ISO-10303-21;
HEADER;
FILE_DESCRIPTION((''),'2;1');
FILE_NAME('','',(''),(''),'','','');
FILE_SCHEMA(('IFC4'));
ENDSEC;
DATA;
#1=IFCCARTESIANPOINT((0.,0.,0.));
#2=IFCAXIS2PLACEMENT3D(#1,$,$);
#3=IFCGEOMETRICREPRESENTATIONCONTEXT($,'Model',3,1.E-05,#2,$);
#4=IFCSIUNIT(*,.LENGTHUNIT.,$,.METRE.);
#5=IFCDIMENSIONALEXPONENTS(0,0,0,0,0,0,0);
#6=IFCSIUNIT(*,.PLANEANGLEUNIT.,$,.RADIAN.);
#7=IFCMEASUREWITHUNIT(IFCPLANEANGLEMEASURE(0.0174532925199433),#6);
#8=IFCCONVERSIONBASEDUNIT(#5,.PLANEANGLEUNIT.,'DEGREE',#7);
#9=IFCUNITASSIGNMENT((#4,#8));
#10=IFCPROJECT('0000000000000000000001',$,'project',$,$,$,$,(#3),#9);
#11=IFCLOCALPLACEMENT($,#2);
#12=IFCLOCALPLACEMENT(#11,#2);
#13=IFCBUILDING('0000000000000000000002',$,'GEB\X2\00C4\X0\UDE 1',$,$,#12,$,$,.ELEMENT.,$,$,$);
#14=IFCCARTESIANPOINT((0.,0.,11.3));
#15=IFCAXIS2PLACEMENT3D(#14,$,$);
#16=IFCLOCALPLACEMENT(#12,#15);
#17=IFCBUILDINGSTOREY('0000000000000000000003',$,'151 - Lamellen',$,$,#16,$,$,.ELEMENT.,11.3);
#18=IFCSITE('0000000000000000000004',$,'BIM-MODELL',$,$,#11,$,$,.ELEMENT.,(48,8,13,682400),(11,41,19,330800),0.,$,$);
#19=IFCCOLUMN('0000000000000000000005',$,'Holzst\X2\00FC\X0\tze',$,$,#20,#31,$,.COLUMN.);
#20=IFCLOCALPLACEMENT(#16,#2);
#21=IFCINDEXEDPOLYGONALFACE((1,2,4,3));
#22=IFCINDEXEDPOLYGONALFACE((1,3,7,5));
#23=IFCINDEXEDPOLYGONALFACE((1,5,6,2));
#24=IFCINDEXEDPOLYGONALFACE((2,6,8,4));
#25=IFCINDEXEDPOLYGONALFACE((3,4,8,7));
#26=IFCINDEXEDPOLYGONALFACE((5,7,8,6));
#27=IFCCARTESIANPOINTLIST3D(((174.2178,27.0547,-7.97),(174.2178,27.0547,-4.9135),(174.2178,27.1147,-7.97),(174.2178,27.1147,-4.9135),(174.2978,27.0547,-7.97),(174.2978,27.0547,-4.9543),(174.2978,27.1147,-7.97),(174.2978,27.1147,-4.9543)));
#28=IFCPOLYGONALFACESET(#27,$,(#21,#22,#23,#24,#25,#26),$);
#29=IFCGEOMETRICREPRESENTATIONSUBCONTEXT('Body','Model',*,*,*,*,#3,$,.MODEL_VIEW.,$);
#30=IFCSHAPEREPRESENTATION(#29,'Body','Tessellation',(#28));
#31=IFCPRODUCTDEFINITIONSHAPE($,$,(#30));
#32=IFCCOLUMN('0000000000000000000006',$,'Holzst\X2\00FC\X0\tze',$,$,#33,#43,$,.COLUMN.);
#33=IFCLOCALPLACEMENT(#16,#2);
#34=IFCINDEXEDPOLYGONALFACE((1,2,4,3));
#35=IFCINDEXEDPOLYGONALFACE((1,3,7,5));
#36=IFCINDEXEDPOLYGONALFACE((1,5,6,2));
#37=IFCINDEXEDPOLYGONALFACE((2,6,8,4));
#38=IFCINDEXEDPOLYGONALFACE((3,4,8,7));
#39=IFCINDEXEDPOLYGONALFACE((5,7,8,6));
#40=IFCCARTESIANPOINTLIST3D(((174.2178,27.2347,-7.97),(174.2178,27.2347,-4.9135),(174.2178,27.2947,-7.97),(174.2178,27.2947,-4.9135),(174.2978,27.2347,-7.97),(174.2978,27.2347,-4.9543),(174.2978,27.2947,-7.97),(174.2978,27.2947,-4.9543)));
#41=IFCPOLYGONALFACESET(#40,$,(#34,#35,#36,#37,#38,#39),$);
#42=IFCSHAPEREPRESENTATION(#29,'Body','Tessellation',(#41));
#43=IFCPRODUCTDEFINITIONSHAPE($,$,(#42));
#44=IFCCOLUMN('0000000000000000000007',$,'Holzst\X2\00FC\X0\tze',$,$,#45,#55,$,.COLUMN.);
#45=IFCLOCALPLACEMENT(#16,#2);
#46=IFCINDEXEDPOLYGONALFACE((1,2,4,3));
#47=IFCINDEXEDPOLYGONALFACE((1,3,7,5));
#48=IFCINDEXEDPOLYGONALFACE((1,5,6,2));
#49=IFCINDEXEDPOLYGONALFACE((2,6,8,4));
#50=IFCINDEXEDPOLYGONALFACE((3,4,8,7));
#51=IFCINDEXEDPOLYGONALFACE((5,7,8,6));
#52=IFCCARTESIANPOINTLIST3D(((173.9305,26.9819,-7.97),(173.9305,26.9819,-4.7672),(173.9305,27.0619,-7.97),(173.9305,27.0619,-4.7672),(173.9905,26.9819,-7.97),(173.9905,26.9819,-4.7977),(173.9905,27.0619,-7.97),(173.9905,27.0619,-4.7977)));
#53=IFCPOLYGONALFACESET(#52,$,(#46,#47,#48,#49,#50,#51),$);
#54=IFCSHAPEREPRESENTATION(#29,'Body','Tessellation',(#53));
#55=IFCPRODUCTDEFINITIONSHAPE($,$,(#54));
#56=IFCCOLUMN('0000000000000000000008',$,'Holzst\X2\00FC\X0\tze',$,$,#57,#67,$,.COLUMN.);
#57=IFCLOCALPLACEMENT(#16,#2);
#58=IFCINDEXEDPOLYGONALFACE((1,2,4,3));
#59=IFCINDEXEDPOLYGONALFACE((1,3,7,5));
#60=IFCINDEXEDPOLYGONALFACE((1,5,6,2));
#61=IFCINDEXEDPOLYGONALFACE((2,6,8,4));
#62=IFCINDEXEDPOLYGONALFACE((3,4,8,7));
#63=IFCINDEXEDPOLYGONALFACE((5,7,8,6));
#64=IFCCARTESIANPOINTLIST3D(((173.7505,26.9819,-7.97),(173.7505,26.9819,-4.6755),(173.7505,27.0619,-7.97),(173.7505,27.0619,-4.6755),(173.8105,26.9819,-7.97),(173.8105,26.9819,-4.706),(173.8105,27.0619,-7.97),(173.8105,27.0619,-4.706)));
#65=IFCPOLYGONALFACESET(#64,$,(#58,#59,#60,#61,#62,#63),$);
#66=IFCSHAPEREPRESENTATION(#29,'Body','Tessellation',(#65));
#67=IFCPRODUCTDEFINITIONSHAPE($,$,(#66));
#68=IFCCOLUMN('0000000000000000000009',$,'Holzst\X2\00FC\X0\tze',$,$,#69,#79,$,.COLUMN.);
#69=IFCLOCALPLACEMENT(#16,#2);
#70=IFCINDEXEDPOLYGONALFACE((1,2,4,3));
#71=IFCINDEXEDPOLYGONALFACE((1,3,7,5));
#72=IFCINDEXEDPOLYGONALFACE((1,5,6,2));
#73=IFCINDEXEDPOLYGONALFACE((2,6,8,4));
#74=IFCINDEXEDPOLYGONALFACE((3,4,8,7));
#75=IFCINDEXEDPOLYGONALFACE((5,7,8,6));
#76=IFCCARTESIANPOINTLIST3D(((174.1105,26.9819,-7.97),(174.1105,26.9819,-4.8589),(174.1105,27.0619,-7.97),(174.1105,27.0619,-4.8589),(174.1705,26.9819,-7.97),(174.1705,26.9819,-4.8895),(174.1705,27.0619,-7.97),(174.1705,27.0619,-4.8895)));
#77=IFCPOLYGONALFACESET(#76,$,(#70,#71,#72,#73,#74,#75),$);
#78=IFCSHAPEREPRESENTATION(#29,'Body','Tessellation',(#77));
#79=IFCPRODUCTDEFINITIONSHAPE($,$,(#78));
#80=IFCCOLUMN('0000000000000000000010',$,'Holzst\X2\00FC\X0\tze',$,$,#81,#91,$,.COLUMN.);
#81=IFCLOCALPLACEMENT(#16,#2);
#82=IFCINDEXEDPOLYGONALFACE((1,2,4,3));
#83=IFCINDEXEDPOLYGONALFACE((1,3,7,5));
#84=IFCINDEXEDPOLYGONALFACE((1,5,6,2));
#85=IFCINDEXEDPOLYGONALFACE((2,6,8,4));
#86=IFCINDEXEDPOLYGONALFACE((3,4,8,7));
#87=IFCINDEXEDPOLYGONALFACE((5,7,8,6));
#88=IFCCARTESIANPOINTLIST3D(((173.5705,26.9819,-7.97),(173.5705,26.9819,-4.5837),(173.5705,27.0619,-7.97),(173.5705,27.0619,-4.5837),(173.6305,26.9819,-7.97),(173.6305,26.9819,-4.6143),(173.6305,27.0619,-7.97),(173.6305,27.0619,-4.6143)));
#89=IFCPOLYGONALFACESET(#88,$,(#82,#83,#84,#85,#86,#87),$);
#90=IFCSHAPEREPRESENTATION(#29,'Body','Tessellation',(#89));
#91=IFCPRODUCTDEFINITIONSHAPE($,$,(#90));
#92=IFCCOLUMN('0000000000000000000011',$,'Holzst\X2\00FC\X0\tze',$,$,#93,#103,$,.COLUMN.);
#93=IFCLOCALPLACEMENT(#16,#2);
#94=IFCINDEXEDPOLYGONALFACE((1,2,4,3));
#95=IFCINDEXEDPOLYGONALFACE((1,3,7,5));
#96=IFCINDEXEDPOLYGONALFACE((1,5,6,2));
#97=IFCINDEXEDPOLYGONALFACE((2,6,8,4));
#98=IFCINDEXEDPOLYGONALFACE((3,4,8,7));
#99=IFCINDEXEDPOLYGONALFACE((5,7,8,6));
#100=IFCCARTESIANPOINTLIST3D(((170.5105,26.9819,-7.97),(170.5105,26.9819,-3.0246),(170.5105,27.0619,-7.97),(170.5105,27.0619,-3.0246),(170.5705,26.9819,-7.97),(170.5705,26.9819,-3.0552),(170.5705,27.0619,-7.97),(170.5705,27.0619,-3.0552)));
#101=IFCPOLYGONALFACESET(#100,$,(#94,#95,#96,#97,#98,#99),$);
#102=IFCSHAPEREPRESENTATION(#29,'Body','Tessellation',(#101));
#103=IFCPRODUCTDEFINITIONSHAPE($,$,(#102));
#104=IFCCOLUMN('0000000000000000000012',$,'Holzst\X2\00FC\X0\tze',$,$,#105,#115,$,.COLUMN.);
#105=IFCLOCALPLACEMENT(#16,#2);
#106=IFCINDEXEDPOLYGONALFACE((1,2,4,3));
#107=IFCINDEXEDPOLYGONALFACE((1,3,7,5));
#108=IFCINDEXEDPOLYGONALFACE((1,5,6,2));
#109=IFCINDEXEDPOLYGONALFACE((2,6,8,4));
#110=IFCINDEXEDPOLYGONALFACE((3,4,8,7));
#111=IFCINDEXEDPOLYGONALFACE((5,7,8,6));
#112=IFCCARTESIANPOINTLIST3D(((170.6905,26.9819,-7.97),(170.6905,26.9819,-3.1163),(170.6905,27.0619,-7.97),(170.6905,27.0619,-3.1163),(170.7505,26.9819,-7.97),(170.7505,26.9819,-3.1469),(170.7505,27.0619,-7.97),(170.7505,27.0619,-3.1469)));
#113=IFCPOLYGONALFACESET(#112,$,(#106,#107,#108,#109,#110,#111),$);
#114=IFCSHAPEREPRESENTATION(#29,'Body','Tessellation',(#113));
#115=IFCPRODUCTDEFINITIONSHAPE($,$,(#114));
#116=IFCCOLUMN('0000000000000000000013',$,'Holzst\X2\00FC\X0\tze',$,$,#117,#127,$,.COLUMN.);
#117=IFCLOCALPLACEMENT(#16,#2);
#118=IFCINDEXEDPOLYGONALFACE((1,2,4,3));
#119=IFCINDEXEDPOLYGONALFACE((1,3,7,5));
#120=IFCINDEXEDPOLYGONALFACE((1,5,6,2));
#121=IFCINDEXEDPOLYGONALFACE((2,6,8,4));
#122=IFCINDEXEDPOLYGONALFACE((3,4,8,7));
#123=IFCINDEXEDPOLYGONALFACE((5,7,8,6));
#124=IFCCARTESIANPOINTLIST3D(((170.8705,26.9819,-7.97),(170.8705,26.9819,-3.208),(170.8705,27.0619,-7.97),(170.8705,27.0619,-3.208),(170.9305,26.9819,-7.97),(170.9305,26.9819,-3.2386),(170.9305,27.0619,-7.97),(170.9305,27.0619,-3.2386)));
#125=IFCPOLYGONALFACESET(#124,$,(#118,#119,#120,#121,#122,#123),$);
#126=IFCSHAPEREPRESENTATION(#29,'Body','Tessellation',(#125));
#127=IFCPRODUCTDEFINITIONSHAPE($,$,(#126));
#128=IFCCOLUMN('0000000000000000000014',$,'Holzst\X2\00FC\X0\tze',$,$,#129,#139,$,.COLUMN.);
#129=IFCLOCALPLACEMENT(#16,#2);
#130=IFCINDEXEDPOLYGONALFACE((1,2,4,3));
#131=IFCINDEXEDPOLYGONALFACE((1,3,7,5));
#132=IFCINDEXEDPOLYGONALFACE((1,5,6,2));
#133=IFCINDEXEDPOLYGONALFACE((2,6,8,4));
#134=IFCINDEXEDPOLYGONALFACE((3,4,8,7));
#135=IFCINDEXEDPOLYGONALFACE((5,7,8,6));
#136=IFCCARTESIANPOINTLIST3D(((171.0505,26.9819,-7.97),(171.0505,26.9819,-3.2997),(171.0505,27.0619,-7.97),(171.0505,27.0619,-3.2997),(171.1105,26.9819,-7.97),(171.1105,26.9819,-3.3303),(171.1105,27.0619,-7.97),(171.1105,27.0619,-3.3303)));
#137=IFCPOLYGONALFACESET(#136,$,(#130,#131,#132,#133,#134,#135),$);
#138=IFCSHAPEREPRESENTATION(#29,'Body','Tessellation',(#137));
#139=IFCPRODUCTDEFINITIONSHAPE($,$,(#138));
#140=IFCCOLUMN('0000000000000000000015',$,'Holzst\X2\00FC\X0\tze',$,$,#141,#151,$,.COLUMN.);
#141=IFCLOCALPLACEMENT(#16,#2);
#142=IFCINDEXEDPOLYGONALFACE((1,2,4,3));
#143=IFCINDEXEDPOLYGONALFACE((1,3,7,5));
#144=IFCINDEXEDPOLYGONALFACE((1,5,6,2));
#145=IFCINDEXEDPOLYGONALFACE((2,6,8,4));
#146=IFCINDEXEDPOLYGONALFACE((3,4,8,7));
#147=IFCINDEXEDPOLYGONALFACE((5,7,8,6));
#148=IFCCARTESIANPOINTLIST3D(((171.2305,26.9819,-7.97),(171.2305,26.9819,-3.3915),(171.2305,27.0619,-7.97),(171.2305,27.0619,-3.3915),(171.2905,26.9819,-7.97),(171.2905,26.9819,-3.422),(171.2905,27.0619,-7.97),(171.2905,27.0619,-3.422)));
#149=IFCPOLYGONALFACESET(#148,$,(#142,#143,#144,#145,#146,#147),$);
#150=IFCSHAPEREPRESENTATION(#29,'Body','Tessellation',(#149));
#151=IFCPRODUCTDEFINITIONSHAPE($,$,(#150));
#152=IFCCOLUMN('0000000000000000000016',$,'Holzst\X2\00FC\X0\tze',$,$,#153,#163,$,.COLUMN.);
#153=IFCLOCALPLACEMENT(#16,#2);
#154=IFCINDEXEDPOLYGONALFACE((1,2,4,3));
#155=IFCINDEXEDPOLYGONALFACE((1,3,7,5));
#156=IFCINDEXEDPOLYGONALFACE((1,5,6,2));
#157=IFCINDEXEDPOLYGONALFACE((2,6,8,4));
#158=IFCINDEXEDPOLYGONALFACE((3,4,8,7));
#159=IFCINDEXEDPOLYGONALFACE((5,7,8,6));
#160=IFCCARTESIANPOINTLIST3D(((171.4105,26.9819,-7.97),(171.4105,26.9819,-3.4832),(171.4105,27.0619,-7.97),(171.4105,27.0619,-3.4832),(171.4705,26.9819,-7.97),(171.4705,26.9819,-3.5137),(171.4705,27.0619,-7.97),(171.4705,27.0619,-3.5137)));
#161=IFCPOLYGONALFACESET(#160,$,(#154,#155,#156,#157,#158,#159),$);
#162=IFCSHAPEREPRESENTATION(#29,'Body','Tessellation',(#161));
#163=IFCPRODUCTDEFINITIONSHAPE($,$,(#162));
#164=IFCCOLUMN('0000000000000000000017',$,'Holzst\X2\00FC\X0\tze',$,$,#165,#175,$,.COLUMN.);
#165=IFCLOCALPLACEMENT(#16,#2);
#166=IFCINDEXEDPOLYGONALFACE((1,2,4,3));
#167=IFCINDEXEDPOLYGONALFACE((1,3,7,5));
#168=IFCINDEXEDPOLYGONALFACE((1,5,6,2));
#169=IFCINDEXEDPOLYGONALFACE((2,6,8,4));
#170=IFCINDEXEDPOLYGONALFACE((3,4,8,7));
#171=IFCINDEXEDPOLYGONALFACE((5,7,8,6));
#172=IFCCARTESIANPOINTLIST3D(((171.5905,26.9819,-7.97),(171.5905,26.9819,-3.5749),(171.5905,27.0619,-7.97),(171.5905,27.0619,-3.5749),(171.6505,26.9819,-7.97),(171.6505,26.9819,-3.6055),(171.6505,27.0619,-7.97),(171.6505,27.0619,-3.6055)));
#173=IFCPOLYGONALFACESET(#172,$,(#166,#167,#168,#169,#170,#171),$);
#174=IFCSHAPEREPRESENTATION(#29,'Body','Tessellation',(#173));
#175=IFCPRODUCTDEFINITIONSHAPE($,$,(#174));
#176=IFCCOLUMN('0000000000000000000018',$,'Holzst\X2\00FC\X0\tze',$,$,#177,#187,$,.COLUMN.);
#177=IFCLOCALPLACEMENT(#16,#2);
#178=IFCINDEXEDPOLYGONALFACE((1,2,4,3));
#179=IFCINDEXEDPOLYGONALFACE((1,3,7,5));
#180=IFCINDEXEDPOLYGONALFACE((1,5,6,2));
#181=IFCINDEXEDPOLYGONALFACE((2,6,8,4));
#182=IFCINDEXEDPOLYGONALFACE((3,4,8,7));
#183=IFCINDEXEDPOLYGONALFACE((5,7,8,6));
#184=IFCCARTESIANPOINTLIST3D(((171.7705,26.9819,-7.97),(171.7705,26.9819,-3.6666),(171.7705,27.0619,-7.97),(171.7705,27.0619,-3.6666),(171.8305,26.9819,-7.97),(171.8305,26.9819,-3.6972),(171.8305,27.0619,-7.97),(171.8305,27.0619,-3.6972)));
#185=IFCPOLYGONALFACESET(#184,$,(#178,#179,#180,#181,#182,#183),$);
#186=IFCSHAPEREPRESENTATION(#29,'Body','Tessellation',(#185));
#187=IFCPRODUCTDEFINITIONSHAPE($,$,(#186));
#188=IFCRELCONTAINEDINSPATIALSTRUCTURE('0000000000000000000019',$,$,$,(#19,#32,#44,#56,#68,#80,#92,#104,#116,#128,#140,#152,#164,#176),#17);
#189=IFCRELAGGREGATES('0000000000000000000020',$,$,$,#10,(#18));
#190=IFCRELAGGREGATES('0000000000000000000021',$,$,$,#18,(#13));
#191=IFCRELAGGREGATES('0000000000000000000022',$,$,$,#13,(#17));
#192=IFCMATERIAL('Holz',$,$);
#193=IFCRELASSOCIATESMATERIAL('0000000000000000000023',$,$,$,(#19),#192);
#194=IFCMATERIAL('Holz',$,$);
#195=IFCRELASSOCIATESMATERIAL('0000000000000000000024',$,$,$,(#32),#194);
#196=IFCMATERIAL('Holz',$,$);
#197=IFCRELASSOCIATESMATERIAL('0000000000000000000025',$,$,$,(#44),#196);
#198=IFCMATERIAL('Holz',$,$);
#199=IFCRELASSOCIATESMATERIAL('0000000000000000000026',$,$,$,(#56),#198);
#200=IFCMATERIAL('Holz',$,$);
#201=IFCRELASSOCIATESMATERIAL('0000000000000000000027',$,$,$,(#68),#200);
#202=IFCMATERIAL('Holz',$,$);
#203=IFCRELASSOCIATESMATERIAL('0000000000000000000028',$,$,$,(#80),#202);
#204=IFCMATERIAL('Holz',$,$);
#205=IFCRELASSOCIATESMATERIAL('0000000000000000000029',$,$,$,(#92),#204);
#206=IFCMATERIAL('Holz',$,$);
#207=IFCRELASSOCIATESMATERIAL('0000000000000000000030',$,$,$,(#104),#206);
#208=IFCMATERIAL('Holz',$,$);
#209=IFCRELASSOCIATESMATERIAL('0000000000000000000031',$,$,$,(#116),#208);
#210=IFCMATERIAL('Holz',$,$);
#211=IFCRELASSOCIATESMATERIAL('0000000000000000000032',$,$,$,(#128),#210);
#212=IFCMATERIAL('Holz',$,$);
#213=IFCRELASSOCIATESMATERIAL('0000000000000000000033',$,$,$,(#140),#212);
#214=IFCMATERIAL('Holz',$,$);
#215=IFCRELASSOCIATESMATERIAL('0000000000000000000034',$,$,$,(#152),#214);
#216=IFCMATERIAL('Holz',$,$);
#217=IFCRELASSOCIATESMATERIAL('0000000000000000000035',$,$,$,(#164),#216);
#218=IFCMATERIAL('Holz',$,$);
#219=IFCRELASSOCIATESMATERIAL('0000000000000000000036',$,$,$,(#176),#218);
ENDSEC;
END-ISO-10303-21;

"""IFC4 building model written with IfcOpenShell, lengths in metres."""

from ifc_helpers import new_model, entity, si_unit, converted_unit, frame, frame_2d, origin, origin_with_axes, place, context, subcontext, project, spatial, rectangle, extrude, clip, halfspace, material, element, save


model = new_model("IFC4")

# Units and contexts
model_context = context("Model", 3, precision=1e-05, world=origin())
body_context = subcontext(model_context, "Body", "Model", "MODEL_VIEW")
ifc_project = project(units=[si_unit("LENGTHUNIT", "METRE"), converted_unit("PLANEANGLEUNIT", "DEGREE", entity("IfcPlaneAngleMeasure", 0.0174532925199433), si_unit("PLANEANGLEUNIT", "RADIAN"), dimensions=[0, 0, 0, 0, 0, 0, 0])], contexts=[model_context])

# Site, building, storey
site_placement = place(None, origin())
site = spatial("IfcSite", under=ifc_project, at=site_placement, Name="BIM-MODELL", CompositionType="ELEMENT", RefLatitude=(48, 8, 13, 682400), RefLongitude=(11, 41, 19, 330800), RefElevation=0.0)
building_placement = place(site_placement, origin())
building = spatial("IfcBuilding", under=site, at=building_placement, Name="GEBÄUDE 1", CompositionType="ELEMENT")
storey_placement = place(building_placement, frame((0.0, 0.0, 11.3)))
storey = spatial("IfcBuildingStorey", under=building, at=storey_placement, Name="151 - Lamellen", CompositionType="ELEMENT", Elevation=11.3)

# Columns
ifc_material_1 = material(Name="Holz")
column_1_placement = place(storey_placement, frame((174.2978, 27.0547, -7.97)))
element("IfcColumn", 1, at=column_1_placement, inside=storey, material=ifc_material_1, Name="Holzstütze", PredefinedType="COLUMN", context=body_context, shape_type="Clipping", body=[
    clip(extrude(rectangle(XDim=0.06, YDim=0.08, at=frame_2d((-0.04, 0.03), x_axis=(0.0, 1.0))), origin_with_axes(), (0.0, 0.0, 1.0), 3.0565), halfspace(frame((-0.04, 0.03, 3.0361), z_axis=(-0.45399, 0.0, -0.891007), x_axis=(0.891007, 0.0, -0.45399)), True)),
])
ifc_material_2 = material(Name="Holz")
column_2_placement = place(storey_placement, frame((174.2978, 27.2347, -7.97)))
element("IfcColumn", 2, at=column_2_placement, inside=storey, material=ifc_material_2, Name="Holzstütze", PredefinedType="COLUMN", context=body_context, shape_type="Clipping", body=[
    clip(extrude(rectangle(XDim=0.06, YDim=0.08, at=frame_2d((-0.04, 0.03), x_axis=(0.0, 1.0))), origin_with_axes(), (0.0, 0.0, 1.0), 3.0565), halfspace(frame((-0.04, 0.03, 3.0361), z_axis=(-0.45399, 0.0, -0.891007), x_axis=(0.891007, 0.0, -0.45399)), True)),
])
ifc_material_3 = material(Name="Holz")
column_3_placement = place(storey_placement, frame((173.9305, 26.9819, -7.97)))
element("IfcColumn", 3, at=column_3_placement, inside=storey, material=ifc_material_3, Name="Holzstütze", PredefinedType="COLUMN", context=body_context, shape_type="Clipping", body=[
    clip(extrude(rectangle(XDim=0.06, YDim=0.08, at=frame_2d((0.03, 0.04), x_axis=(1.0, 0.0))), origin_with_axes(), (0.0, 0.0, 1.0), 3.2028), halfspace(frame((0.03, 0.04, 3.1875), z_axis=(-0.45399, 0.0, -0.891007), x_axis=(0.0, -1.0, 0.0)), True)),
])
ifc_material_4 = material(Name="Holz")
column_4_placement = place(storey_placement, frame((173.7505, 26.9819, -7.97)))
element("IfcColumn", 4, at=column_4_placement, inside=storey, material=ifc_material_4, Name="Holzstütze", PredefinedType="COLUMN", context=body_context, shape_type="Clipping", body=[
    clip(extrude(rectangle(XDim=0.06, YDim=0.08, at=frame_2d((0.03, 0.04), x_axis=(1.0, 0.0))), origin_with_axes(), (0.0, 0.0, 1.0), 3.2945), halfspace(frame((0.03, 0.04, 3.2793), z_axis=(-0.45399, 0.0, -0.891007), x_axis=(0.0, -1.0, 0.0)), True)),
])
ifc_material_5 = material(Name="Holz")
column_5_placement = place(storey_placement, frame((174.1105, 26.9819, -7.97)))
element("IfcColumn", 5, at=column_5_placement, inside=storey, material=ifc_material_5, Name="Holzstütze", PredefinedType="COLUMN", context=body_context, shape_type="Clipping", body=[
    clip(extrude(rectangle(XDim=0.06, YDim=0.08, at=frame_2d((0.03, 0.04), x_axis=(1.0, 0.0))), origin_with_axes(), (0.0, 0.0, 1.0), 3.1111), halfspace(frame((0.03, 0.04, 3.0958), z_axis=(-0.45399, 0.0, -0.891007), x_axis=(0.0, -1.0, 0.0)), True)),
])
ifc_material_6 = material(Name="Holz")
column_6_placement = place(storey_placement, frame((173.5705, 26.9819, -7.97)))
element("IfcColumn", 6, at=column_6_placement, inside=storey, material=ifc_material_6, Name="Holzstütze", PredefinedType="COLUMN", context=body_context, shape_type="Clipping", body=[
    clip(extrude(rectangle(XDim=0.06, YDim=0.08, at=frame_2d((0.03, 0.04), x_axis=(1.0, 0.0))), origin_with_axes(), (0.0, 0.0, 1.0), 3.3863), halfspace(frame((0.03, 0.04, 3.371), z_axis=(-0.45399, 0.0, -0.891007), x_axis=(0.0, -1.0, 0.0)), True)),
])
ifc_material_7 = material(Name="Holz")
column_7_placement = place(storey_placement, frame((170.5105, 26.9819, -7.97)))
element("IfcColumn", 7, at=column_7_placement, inside=storey, material=ifc_material_7, Name="Holzstütze", PredefinedType="COLUMN", context=body_context, shape_type="Clipping", body=[
    clip(extrude(rectangle(XDim=0.06, YDim=0.08, at=frame_2d((0.03, 0.04), x_axis=(1.0, 0.0))), origin_with_axes(), (0.0, 0.0, 1.0), 4.9454), halfspace(frame((0.03, 0.04, 4.9301), z_axis=(-0.45399, 0.0, -0.891007), x_axis=(0.0, -1.0, 0.0)), True)),
])
ifc_material_8 = material(Name="Holz")
column_8_placement = place(storey_placement, frame((170.6905, 26.9819, -7.97)))
element("IfcColumn", 8, at=column_8_placement, inside=storey, material=ifc_material_8, Name="Holzstütze", PredefinedType="COLUMN", context=body_context, shape_type="Clipping", body=[
    clip(extrude(rectangle(XDim=0.06, YDim=0.08, at=frame_2d((0.03, 0.04), x_axis=(1.0, 0.0))), origin_with_axes(), (0.0, 0.0, 1.0), 4.8537), halfspace(frame((0.03, 0.04, 4.8384), z_axis=(-0.45399, 0.0, -0.891007), x_axis=(0.0, -1.0, 0.0)), True)),
])
ifc_material_9 = material(Name="Holz")
column_9_placement = place(storey_placement, frame((170.8705, 26.9819, -7.97)))
element("IfcColumn", 9, at=column_9_placement, inside=storey, material=ifc_material_9, Name="Holzstütze", PredefinedType="COLUMN", context=body_context, shape_type="Clipping", body=[
    clip(extrude(rectangle(XDim=0.06, YDim=0.08, at=frame_2d((0.03, 0.04), x_axis=(1.0, 0.0))), origin_with_axes(), (0.0, 0.0, 1.0), 4.762), halfspace(frame((0.03, 0.04, 4.7467), z_axis=(-0.45399, 0.0, -0.891007), x_axis=(0.0, -1.0, 0.0)), True)),
])
ifc_material_10 = material(Name="Holz")
column_10_placement = place(storey_placement, frame((171.0505, 26.9819, -7.97)))
element("IfcColumn", 10, at=column_10_placement, inside=storey, material=ifc_material_10, Name="Holzstütze", PredefinedType="COLUMN", context=body_context, shape_type="Clipping", body=[
    clip(extrude(rectangle(XDim=0.06, YDim=0.08, at=frame_2d((0.03, 0.04), x_axis=(1.0, 0.0))), origin_with_axes(), (0.0, 0.0, 1.0), 4.6703), halfspace(frame((0.03, 0.04, 4.655), z_axis=(-0.45399, 0.0, -0.891007), x_axis=(0.0, -1.0, 0.0)), True)),
])
ifc_material_11 = material(Name="Holz")
column_11_placement = place(storey_placement, frame((171.2305, 26.9819, -7.97)))
element("IfcColumn", 11, at=column_11_placement, inside=storey, material=ifc_material_11, Name="Holzstütze", PredefinedType="COLUMN", context=body_context, shape_type="Clipping", body=[
    clip(extrude(rectangle(XDim=0.06, YDim=0.08, at=frame_2d((0.03, 0.04), x_axis=(1.0, 0.0))), origin_with_axes(), (0.0, 0.0, 1.0), 4.5785), halfspace(frame((0.03, 0.04, 4.5633), z_axis=(-0.45399, 0.0, -0.891007), x_axis=(0.0, -1.0, 0.0)), True)),
])
ifc_material_12 = material(Name="Holz")
column_12_placement = place(storey_placement, frame((171.4105, 26.9819, -7.97)))
element("IfcColumn", 12, at=column_12_placement, inside=storey, material=ifc_material_12, Name="Holzstütze", PredefinedType="COLUMN", context=body_context, shape_type="Clipping", body=[
    clip(extrude(rectangle(XDim=0.06, YDim=0.08, at=frame_2d((0.03, 0.04), x_axis=(1.0, 0.0))), origin_with_axes(), (0.0, 0.0, 1.0), 4.4868), halfspace(frame((0.03, 0.04, 4.4715), z_axis=(-0.45399, 0.0, -0.891007), x_axis=(0.0, -1.0, 0.0)), True)),
])
ifc_material_13 = material(Name="Holz")
column_13_placement = place(storey_placement, frame((171.5905, 26.9819, -7.97)))
element("IfcColumn", 13, at=column_13_placement, inside=storey, material=ifc_material_13, Name="Holzstütze", PredefinedType="COLUMN", context=body_context, shape_type="Clipping", body=[
    clip(extrude(rectangle(XDim=0.06, YDim=0.08, at=frame_2d((0.03, 0.04), x_axis=(1.0, 0.0))), origin_with_axes(), (0.0, 0.0, 1.0), 4.3951), halfspace(frame((0.03, 0.04, 4.3798), z_axis=(-0.45399, 0.0, -0.891007), x_axis=(0.0, -1.0, 0.0)), True)),
])
ifc_material_14 = material(Name="Holz")
column_14_placement = place(storey_placement, frame((171.7705, 26.9819, -7.97)))
element("IfcColumn", 14, at=column_14_placement, inside=storey, material=ifc_material_14, Name="Holzstütze", PredefinedType="COLUMN", context=body_context, shape_type="Clipping", body=[
    clip(extrude(rectangle(XDim=0.06, YDim=0.08, at=frame_2d((0.03, 0.04), x_axis=(1.0, 0.0))), origin_with_axes(), (0.0, 0.0, 1.0), 4.3034), halfspace(frame((0.03, 0.04, 4.2881), z_axis=(-0.45399, 0.0, -0.891007), x_axis=(0.0, -1.0, 0.0)), True)),
])

save(model, "model.ifc")
